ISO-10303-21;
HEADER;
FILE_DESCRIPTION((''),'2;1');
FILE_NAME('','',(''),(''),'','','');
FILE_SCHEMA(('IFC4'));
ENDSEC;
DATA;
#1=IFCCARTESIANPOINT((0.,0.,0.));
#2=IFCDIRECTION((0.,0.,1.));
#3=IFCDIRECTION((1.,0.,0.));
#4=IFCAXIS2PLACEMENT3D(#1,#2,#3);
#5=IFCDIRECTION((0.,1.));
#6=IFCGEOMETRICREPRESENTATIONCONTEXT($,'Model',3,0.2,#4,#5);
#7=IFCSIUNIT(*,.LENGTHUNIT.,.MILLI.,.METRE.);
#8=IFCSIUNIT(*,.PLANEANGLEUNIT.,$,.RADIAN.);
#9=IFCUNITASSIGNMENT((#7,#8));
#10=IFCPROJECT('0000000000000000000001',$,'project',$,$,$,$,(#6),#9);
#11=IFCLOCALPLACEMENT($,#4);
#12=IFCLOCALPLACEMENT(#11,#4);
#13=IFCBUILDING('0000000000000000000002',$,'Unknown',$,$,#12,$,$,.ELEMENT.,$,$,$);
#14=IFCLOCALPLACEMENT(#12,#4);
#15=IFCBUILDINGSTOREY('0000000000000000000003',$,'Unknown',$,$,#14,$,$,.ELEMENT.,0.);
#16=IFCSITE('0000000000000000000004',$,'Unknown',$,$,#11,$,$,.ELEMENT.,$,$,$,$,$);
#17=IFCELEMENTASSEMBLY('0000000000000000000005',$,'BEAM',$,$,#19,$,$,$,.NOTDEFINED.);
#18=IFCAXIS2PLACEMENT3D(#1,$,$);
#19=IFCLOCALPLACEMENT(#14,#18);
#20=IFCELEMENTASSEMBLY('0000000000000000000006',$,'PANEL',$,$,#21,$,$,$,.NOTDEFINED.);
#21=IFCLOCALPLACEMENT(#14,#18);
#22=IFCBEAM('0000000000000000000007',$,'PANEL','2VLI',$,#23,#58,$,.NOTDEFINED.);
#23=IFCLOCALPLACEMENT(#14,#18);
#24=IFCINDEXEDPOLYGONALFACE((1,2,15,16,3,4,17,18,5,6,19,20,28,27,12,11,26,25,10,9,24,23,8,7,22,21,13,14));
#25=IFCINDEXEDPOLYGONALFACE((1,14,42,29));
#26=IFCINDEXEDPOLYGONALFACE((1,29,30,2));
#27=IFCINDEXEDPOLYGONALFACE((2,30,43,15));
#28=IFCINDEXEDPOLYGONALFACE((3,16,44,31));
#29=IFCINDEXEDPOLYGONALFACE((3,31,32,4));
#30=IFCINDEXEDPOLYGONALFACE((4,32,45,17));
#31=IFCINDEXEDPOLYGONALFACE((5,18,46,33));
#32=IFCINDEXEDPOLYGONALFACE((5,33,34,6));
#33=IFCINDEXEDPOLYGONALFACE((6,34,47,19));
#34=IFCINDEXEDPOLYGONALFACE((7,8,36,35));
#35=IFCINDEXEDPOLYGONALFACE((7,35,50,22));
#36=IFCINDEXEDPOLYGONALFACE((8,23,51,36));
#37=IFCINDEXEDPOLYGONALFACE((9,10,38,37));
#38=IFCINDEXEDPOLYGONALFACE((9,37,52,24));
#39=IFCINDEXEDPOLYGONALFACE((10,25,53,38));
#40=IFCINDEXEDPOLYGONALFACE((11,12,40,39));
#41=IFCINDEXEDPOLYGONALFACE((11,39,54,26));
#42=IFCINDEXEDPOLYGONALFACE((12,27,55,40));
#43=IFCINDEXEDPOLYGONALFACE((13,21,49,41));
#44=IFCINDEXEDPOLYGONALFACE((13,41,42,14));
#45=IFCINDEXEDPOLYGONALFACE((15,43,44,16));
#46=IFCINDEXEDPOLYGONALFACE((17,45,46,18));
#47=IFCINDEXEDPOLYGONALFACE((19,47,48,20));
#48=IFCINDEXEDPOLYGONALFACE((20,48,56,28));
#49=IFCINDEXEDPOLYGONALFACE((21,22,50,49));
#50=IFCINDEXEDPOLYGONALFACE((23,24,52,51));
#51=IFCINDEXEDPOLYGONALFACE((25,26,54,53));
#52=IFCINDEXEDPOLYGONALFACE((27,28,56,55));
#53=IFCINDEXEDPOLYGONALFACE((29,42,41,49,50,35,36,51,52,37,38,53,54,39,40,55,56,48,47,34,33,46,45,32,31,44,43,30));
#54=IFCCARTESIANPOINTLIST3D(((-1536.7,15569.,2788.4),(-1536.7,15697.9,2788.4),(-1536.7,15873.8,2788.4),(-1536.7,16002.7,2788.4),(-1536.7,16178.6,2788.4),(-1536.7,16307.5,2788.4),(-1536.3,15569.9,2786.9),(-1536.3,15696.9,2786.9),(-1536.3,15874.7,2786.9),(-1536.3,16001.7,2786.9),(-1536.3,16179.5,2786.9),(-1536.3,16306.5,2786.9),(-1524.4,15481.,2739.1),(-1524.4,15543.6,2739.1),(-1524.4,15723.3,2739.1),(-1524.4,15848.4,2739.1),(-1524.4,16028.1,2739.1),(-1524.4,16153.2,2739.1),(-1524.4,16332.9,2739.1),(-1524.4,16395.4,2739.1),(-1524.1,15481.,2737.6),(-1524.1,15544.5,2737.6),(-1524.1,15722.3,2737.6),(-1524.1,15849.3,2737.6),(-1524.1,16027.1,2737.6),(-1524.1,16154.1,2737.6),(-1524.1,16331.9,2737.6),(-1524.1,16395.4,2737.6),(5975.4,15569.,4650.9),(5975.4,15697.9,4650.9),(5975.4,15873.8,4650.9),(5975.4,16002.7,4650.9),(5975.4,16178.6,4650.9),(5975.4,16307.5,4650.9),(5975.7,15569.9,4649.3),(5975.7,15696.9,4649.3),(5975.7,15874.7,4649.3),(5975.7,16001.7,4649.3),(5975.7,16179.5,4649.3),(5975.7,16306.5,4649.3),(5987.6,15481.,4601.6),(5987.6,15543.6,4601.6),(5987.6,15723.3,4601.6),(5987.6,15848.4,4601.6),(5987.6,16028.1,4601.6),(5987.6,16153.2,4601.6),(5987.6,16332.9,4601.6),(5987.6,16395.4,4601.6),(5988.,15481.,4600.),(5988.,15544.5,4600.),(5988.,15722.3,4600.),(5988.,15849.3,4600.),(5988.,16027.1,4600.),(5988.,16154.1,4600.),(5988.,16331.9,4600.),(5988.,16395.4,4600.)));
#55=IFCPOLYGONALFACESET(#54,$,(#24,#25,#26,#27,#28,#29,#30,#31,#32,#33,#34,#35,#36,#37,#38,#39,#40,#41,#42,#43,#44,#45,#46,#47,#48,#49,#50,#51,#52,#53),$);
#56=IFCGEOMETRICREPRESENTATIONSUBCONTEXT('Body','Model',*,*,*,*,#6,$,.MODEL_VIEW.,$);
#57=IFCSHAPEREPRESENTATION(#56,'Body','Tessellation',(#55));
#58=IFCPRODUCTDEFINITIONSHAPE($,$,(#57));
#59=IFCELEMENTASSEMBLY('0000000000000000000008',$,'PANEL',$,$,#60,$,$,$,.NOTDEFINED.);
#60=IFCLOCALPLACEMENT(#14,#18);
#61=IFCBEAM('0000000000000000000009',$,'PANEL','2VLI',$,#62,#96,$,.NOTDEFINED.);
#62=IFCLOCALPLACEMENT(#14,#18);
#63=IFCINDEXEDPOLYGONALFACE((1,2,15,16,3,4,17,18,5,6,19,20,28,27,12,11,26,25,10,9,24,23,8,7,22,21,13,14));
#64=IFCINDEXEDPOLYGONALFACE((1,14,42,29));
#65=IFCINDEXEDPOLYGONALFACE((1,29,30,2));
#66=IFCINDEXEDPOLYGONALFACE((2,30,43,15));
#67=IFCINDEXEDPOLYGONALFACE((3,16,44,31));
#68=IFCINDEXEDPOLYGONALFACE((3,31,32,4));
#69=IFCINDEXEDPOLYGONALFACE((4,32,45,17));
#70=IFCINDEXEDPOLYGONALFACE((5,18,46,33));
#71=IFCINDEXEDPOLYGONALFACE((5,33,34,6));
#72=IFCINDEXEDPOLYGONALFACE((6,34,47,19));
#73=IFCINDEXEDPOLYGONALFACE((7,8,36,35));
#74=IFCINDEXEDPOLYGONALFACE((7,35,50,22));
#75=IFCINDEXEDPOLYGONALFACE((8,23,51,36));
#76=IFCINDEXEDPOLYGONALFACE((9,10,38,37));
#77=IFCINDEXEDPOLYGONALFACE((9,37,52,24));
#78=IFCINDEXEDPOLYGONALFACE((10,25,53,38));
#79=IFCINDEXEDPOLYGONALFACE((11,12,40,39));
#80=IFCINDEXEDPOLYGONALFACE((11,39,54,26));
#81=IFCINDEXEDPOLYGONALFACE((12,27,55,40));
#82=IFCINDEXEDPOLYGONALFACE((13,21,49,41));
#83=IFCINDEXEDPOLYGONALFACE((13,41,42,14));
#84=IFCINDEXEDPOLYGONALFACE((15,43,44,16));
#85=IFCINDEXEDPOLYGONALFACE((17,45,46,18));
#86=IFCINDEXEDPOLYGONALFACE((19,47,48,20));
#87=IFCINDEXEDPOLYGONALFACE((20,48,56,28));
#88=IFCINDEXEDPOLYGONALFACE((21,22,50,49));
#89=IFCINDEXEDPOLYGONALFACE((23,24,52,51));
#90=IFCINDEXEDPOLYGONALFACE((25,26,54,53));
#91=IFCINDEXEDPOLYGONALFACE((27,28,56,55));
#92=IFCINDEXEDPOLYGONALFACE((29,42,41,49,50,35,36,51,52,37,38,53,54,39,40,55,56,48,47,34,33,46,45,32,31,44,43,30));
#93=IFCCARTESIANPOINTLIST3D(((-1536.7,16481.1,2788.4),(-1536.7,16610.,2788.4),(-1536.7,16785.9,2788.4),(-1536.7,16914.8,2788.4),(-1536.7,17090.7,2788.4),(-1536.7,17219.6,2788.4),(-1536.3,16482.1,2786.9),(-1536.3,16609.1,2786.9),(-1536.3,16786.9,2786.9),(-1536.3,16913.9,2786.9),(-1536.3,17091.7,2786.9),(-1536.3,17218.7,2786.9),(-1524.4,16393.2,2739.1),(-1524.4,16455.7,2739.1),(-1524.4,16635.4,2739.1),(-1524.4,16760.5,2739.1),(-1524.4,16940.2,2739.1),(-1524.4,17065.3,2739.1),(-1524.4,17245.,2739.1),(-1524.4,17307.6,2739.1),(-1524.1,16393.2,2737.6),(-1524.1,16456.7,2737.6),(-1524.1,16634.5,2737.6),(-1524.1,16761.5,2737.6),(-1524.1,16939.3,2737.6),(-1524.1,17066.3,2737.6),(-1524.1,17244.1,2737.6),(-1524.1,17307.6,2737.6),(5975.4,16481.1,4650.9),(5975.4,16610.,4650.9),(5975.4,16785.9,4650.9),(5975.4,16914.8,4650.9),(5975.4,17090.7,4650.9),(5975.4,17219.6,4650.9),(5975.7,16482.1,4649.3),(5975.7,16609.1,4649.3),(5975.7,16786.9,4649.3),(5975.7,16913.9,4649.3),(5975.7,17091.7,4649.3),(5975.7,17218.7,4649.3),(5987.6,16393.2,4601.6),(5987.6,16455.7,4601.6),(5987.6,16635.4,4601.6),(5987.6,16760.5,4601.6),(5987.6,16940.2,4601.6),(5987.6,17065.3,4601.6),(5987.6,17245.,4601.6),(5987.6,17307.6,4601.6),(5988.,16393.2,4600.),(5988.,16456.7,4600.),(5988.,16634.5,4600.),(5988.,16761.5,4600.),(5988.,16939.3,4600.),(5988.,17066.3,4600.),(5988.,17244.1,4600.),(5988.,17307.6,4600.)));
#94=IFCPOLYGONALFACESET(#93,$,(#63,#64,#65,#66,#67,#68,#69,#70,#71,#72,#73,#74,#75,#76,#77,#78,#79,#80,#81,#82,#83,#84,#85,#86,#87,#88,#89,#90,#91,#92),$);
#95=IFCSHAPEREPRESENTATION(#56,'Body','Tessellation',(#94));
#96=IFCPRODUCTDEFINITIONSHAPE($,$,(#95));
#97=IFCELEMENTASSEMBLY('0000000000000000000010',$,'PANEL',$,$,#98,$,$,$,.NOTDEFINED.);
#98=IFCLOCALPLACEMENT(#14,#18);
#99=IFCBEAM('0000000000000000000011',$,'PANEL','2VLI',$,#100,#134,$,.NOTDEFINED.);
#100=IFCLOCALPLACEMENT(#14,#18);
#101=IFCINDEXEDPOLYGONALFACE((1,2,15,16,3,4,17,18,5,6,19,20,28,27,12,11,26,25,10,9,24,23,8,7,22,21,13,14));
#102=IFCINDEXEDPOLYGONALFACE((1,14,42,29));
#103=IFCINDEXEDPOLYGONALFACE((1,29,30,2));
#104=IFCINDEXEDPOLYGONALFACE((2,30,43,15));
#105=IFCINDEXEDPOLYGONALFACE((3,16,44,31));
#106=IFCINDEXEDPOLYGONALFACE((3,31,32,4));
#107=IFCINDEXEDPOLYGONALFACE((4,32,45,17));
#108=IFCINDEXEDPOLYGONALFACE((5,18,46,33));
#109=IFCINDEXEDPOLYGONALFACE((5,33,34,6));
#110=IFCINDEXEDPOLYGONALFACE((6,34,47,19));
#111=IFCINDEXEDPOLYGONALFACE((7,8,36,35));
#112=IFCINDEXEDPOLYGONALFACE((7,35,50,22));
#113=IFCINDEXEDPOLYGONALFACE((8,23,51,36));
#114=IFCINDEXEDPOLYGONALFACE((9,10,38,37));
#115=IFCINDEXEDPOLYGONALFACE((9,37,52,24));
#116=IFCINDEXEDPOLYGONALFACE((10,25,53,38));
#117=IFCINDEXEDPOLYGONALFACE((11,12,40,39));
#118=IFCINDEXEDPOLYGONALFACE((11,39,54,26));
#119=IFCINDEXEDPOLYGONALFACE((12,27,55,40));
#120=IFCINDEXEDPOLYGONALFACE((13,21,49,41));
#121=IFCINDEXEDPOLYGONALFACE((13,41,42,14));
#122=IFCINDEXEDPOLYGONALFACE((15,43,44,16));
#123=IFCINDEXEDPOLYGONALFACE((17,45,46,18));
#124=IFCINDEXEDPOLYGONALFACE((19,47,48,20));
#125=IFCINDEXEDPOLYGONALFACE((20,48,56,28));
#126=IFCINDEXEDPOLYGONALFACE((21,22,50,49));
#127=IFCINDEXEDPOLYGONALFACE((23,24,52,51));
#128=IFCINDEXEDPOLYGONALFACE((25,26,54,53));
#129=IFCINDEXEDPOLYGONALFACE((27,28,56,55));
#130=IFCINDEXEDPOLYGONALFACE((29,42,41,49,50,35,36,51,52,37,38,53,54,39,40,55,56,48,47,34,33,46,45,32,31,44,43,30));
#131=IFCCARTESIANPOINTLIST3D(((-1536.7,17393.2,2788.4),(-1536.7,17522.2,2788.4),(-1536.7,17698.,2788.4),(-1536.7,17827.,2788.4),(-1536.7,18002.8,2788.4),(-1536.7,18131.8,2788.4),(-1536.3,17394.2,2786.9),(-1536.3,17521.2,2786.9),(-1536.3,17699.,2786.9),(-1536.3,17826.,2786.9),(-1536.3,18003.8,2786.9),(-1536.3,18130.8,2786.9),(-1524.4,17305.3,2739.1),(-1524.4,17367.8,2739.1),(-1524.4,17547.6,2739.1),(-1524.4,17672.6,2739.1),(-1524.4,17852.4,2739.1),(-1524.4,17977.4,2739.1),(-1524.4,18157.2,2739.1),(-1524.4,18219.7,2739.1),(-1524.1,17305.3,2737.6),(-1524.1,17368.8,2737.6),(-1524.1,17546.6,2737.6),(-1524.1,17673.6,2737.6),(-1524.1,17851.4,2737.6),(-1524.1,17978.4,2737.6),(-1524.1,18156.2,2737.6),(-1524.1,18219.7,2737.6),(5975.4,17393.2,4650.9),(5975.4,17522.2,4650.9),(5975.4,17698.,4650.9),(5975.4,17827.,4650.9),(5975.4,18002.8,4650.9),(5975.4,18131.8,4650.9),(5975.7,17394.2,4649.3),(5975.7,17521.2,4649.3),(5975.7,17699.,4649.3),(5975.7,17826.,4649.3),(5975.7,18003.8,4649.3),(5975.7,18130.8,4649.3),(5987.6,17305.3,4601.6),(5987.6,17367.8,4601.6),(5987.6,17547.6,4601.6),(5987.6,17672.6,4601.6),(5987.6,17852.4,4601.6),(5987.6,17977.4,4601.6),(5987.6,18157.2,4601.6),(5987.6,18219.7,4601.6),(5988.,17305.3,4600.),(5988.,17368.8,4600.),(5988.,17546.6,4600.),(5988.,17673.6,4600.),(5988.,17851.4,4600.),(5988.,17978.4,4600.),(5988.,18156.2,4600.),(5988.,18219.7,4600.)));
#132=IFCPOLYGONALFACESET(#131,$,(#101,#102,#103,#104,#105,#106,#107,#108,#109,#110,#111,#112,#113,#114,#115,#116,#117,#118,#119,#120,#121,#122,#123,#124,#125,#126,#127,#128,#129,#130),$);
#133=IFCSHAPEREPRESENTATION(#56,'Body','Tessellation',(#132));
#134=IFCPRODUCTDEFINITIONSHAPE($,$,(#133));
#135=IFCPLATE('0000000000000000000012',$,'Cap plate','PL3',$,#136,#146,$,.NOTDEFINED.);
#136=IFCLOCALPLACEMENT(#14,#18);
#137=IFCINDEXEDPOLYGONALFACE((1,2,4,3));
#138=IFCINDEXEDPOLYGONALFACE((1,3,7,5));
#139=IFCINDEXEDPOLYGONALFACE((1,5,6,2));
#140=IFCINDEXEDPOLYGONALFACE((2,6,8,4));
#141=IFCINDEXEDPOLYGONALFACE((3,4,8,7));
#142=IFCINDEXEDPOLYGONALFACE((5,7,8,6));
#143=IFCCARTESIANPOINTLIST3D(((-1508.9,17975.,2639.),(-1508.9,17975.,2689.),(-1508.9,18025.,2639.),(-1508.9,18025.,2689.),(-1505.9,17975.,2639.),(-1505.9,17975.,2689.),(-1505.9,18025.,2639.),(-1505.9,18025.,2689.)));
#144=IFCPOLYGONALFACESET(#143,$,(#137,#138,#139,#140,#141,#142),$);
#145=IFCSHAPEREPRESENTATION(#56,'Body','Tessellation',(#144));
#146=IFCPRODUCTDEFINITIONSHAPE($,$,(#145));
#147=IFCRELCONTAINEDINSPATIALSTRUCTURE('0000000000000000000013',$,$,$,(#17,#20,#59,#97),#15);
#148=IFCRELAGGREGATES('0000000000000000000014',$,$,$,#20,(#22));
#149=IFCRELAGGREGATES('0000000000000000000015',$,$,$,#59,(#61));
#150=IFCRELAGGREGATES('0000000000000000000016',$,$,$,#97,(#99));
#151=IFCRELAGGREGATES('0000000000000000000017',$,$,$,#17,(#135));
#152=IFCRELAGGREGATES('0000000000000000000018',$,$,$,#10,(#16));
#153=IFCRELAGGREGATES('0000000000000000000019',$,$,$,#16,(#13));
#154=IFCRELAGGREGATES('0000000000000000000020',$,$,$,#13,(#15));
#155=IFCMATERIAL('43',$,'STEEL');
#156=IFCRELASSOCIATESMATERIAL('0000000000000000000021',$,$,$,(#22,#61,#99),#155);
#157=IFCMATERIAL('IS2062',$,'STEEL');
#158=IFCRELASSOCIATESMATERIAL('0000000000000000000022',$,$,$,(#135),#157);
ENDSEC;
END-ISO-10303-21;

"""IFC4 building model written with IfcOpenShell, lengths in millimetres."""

from ifc_helpers import new_model, si_unit, direction, frame, origin_with_axes, place, context, subcontext, project, spatial, line, indexed_curve, outline, extrude, material, element, aggregate, save


model = new_model("IFC4")

# Units and contexts
model_context = context("Model", 3, precision=0.2, world=origin_with_axes(), true_north=direction((0.0, 1.0)))
body_context = subcontext(model_context, "Body", "Model", "MODEL_VIEW")
ifc_project = project(units=[si_unit("LENGTHUNIT", "METRE", prefix="MILLI"), si_unit("PLANEANGLEUNIT", "RADIAN")], contexts=[model_context])

# Site, building, storey
site_placement = place(None, origin_with_axes())
site = spatial("IfcSite", under=ifc_project, at=site_placement, Name="Unknown", CompositionType="ELEMENT")
building_placement = place(site_placement, origin_with_axes())
building = spatial("IfcBuilding", under=site, at=building_placement, Name="Unknown", CompositionType="ELEMENT")
storey_placement = place(building_placement, origin_with_axes())
storey = spatial("IfcBuildingStorey", under=building, at=storey_placement, Name="Unknown", CompositionType="ELEMENT", Elevation=0.0)

# Element assembly
ifc_material_1 = material(Name="IS2062", Category="STEEL")
assembly_1_placement = place(storey_placement, frame((-1505.9, 18000.0, 2664.0), z_axis=(0.0, -1.0, 0.0), x_axis=(1.0, 0.0, 0.0)))
assembly_1 = element("IfcElementAssembly", 1, at=assembly_1_placement, inside=storey, Name="BEAM", PredefinedType="NOTDEFINED")

# Element assemblies, beams
ifc_material_2 = material(Name="43", Category="STEEL")
assembly_2_placement = place(storey_placement, frame((-1530.4, 15938.2, 2763.0), z_axis=(0.0, -1.0, 0.0), x_axis=(0.970613, 0.0, 0.240648)))
assembly_2 = element("IfcElementAssembly", 2, at=assembly_2_placement, inside=storey, Name="PANEL", PredefinedType="NOTDEFINED")
beam_1_placement = place(assembly_2_placement, origin_with_axes())
beam_1 = element("IfcBeam", 3, at=beam_1_placement, material=ifc_material_2, Name="PANEL", Description="2VLI", PredefinedType="NOTDEFINED", context=body_context, shape_type="SolidModel", body=[
    extrude(outline(indexed_curve([(457.2, -26.2), (457.2, -24.6), (394.7, -24.6), (369.3, 26.2), (240.3, 26.2), (214.9, -24.6), (89.9, -24.6), (64.5, 26.2), (-64.5, 26.2), (-89.9, -24.6), (-214.9, -24.6), (-240.3, 26.2), (-369.3, 26.2), (-394.7, -24.6), (-457.2, -24.6), (-457.2, -26.2), (-393.7, -26.2), (-368.3, 24.6), (-241.3, 24.6), (-215.9, -26.2), (-88.9, -26.2), (-63.5, 24.6), (63.5, 24.6), (88.9, -26.2), (215.9, -26.2), (241.3, 24.6), (368.3, 24.6), (393.7, -26.2)], segments=[line(1, 2, 3, 4, 5, 6, 7, 8, 9, 10, 11, 12, 13, 14, 15, 16, 17, 18, 19, 20, 21, 22, 23, 24, 25, 26, 27, 28, 1)])), frame((0.0, 0.0, 0.0), z_axis=(-1.0, 0.0, 0.0), x_axis=(0.0, 0.0, 1.0)), (0.0, 0.0, -1.0), 7739.5),
])
aggregate(assembly_2, [beam_1])
assembly_3_placement = place(storey_placement, frame((-1530.4, 16850.4, 2763.0), z_axis=(0.0, -1.0, 0.0), x_axis=(0.970613, 0.0, 0.240648)))
assembly_3 = element("IfcElementAssembly", 4, at=assembly_3_placement, inside=storey, Name="PANEL", PredefinedType="NOTDEFINED")
beam_2_placement = place(assembly_3_placement, origin_with_axes())
beam_2 = element("IfcBeam", 5, at=beam_2_placement, material=ifc_material_2, Name="PANEL", Description="2VLI", PredefinedType="NOTDEFINED", context=body_context, shape_type="SolidModel", body=[
    extrude(outline(indexed_curve([(457.2, -26.2), (457.2, -24.6), (394.7, -24.6), (369.3, 26.2), (240.3, 26.2), (214.9, -24.6), (89.9, -24.6), (64.5, 26.2), (-64.5, 26.2), (-89.9, -24.6), (-214.9, -24.6), (-240.3, 26.2), (-369.3, 26.2), (-394.7, -24.6), (-457.2, -24.6), (-457.2, -26.2), (-393.7, -26.2), (-368.3, 24.6), (-241.3, 24.6), (-215.9, -26.2), (-88.9, -26.2), (-63.5, 24.6), (63.5, 24.6), (88.9, -26.2), (215.9, -26.2), (241.3, 24.6), (368.3, 24.6), (393.7, -26.2)], segments=[line(1, 2, 3, 4, 5, 6, 7, 8, 9, 10, 11, 12, 13, 14, 15, 16, 17, 18, 19, 20, 21, 22, 23, 24, 25, 26, 27, 28, 1)])), frame((0.0, 0.0, 0.0), z_axis=(-1.0, 0.0, 0.0), x_axis=(0.0, 0.0, 1.0)), (0.0, 0.0, -1.0), 7739.5),
])
aggregate(assembly_3, [beam_2])
assembly_4_placement = place(storey_placement, frame((-1530.4, 17762.5, 2763.0), z_axis=(0.0, -1.0, 0.0), x_axis=(0.970613, 0.0, 0.240648)))
assembly_4 = element("IfcElementAssembly", 6, at=assembly_4_placement, inside=storey, Name="PANEL", PredefinedType="NOTDEFINED")
beam_3_placement = place(assembly_4_placement, origin_with_axes())
beam_3 = element("IfcBeam", 7, at=beam_3_placement, material=ifc_material_2, Name="PANEL", Description="2VLI", PredefinedType="NOTDEFINED", context=body_context, shape_type="SolidModel", body=[
    extrude(outline(indexed_curve([(457.2, -26.2), (457.2, -24.6), (394.7, -24.6), (369.3, 26.2), (240.3, 26.2), (214.9, -24.6), (89.9, -24.6), (64.5, 26.2), (-64.5, 26.2), (-89.9, -24.6), (-214.9, -24.6), (-240.3, 26.2), (-369.3, 26.2), (-394.7, -24.6), (-457.2, -24.6), (-457.2, -26.2), (-393.7, -26.2), (-368.3, 24.6), (-241.3, 24.6), (-215.9, -26.2), (-88.9, -26.2), (-63.5, 24.6), (63.5, 24.6), (88.9, -26.2), (215.9, -26.2), (241.3, 24.6), (368.3, 24.6), (393.7, -26.2)], segments=[line(1, 2, 3, 4, 5, 6, 7, 8, 9, 10, 11, 12, 13, 14, 15, 16, 17, 18, 19, 20, 21, 22, 23, 24, 25, 26, 27, 28, 1)])), frame((0.0, 0.0, 0.0), z_axis=(-1.0, 0.0, 0.0), x_axis=(0.0, 0.0, 1.0)), (0.0, 0.0, -1.0), 7739.5),
])
aggregate(assembly_4, [beam_3])

# Plate
plate_placement = place(assembly_1_placement, frame((-1.5, 25.0, 25.0), z_axis=(-1.0, 0.0, 0.0), x_axis=(0.0, 0.0, -1.0)))
plate = element("IfcPlate", 8, at=plate_placement, material=ifc_material_1, Name="Cap plate", Description="PL3", PredefinedType="NOTDEFINED", context=body_context, shape_type="SolidModel", body=[
    extrude(outline(indexed_curve([(0.0, 0.0), (50.0, 0.0), (50.0, 50.0), (0.0, 50.0)], segments=[line(1, 2, 3, 4, 1)])), frame((0.0, 0.0, 1.5), z_axis=(0.0, 0.0, 1.0), x_axis=(1.0, 0.0, 0.0)), (0.0, 0.0, -1.0), 3.0),
])
aggregate(assembly_1, [plate])

save(model, "model.ifc")
